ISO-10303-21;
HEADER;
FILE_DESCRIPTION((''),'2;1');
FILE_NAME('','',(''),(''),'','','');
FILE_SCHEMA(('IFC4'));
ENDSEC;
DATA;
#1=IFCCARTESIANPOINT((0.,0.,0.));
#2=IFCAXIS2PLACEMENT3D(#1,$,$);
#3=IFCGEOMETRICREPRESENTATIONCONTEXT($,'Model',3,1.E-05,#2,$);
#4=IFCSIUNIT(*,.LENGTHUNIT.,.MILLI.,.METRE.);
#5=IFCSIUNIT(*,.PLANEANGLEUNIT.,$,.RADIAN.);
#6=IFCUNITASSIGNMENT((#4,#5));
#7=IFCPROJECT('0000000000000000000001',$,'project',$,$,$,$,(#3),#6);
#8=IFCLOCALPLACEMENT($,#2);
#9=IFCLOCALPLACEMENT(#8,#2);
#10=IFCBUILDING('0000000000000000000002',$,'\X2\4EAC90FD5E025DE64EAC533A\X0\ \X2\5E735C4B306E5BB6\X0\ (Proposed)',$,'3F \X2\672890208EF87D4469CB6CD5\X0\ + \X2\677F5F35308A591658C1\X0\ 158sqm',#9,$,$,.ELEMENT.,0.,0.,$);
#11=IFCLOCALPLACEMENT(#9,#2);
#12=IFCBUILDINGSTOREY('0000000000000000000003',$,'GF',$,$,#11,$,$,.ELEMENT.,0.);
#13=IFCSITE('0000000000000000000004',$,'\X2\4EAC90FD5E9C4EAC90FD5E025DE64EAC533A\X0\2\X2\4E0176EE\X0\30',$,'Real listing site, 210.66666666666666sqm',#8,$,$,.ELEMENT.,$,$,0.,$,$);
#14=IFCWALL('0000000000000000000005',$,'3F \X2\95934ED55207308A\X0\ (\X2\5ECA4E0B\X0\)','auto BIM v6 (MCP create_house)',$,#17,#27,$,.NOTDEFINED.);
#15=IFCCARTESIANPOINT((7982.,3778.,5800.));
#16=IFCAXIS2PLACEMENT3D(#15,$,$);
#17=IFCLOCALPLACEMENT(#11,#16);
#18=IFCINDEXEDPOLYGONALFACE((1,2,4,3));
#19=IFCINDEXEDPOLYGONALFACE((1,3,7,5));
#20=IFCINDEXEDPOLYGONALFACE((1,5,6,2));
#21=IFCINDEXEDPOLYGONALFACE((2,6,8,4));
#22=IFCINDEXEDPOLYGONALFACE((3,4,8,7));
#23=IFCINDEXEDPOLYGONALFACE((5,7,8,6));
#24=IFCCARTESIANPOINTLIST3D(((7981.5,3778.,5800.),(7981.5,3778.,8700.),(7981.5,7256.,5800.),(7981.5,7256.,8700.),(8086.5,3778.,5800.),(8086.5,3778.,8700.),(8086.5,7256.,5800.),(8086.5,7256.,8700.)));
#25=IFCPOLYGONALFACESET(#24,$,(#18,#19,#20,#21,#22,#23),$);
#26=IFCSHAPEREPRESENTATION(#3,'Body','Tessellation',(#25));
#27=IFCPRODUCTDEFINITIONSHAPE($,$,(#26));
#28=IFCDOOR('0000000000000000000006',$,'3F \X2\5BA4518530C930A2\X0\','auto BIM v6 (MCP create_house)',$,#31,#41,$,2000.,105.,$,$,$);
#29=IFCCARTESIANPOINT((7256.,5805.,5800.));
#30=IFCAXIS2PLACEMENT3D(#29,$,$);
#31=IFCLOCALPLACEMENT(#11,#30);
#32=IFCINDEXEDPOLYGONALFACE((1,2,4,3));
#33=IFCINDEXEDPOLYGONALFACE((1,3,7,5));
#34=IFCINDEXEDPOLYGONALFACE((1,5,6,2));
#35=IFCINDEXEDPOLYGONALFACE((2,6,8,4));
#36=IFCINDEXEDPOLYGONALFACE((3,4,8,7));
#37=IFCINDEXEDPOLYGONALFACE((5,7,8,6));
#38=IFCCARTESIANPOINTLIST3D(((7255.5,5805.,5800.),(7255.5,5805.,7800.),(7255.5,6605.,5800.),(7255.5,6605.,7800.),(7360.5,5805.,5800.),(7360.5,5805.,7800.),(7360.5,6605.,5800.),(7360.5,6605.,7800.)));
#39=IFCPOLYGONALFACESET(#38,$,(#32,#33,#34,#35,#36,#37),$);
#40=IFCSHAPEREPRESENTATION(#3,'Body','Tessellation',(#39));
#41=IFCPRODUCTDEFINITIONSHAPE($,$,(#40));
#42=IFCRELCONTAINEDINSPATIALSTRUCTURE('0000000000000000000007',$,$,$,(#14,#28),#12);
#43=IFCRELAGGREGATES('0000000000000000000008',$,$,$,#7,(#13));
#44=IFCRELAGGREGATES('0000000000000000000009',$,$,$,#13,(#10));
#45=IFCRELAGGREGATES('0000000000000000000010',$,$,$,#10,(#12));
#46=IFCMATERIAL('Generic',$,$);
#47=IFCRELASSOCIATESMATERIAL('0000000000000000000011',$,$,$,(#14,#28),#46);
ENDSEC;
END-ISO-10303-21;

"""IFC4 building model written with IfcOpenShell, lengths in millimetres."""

from ifc_helpers import new_model, si_unit, frame, frame_2d, origin, place, context, project, spatial, rectangle, extrude, material, element, save


model = new_model("IFC4")

# Units and contexts
model_context = context("Model", 3, precision=1e-05, world=origin())
ifc_project = project(units=[si_unit("LENGTHUNIT", "METRE", prefix="MILLI"), si_unit("PLANEANGLEUNIT", "RADIAN")], contexts=[model_context])

# Site, building, storey
site_placement = place(None, origin())
site = spatial("IfcSite", under=ifc_project, at=site_placement, Name="京都府京都市左京区2丁目30", ObjectType="Real listing site, 210.66666666666666sqm", CompositionType="ELEMENT", RefElevation=0.0)
building_placement = place(site_placement, origin())
building = spatial("IfcBuilding", under=site, at=building_placement, Name="京都市左京区 平屋の家 (Proposed)", ObjectType="3F 木造軸組構法 + 板張り外壁 158sqm", CompositionType="ELEMENT", ElevationOfRefHeight=0.0, ElevationOfTerrain=0.0)
storey_placement = place(building_placement, origin())
storey = spatial("IfcBuildingStorey", under=building, at=storey_placement, Name="GF", CompositionType="ELEMENT", Elevation=0.0)

# Shared definitions
ifc_material = material(Name="Generic")

# Wall
wall_1_placement = place(storey_placement, frame((7982.0, 3778.0, 5800.0)))
element("IfcWall", 1, at=wall_1_placement, inside=storey, material=ifc_material, Name="3F 間仕切り (廊下)", Description="auto BIM v6 (MCP create_house)", PredefinedType="NOTDEFINED", context=model_context, shape_type="SweptSolid", body=[
    extrude(rectangle(XDim=105.0, YDim=3478.0, at=frame_2d((52.0, 1739.0))), frame((7982.0, 3778.0, 5800.0)), (0.0, 0.0, 1.0), 2900.0),
])

# Door
door_1_placement = place(storey_placement, frame((7256.0, 5805.0, 5800.0)))
element("IfcDoor", 2, at=door_1_placement, inside=storey, material=ifc_material, Name="3F 室内ドア", Description="auto BIM v6 (MCP create_house)", OverallHeight=2000.0, OverallWidth=105.0, context=model_context, shape_type="SweptSolid", body=[
    extrude(rectangle(XDim=105.0, YDim=800.0, at=frame_2d((52.0, 400.0))), frame((7256.0, 5805.0, 5800.0)), (0.0, 0.0, 1.0), 2000.0),
])

save(model, "model.ifc")
